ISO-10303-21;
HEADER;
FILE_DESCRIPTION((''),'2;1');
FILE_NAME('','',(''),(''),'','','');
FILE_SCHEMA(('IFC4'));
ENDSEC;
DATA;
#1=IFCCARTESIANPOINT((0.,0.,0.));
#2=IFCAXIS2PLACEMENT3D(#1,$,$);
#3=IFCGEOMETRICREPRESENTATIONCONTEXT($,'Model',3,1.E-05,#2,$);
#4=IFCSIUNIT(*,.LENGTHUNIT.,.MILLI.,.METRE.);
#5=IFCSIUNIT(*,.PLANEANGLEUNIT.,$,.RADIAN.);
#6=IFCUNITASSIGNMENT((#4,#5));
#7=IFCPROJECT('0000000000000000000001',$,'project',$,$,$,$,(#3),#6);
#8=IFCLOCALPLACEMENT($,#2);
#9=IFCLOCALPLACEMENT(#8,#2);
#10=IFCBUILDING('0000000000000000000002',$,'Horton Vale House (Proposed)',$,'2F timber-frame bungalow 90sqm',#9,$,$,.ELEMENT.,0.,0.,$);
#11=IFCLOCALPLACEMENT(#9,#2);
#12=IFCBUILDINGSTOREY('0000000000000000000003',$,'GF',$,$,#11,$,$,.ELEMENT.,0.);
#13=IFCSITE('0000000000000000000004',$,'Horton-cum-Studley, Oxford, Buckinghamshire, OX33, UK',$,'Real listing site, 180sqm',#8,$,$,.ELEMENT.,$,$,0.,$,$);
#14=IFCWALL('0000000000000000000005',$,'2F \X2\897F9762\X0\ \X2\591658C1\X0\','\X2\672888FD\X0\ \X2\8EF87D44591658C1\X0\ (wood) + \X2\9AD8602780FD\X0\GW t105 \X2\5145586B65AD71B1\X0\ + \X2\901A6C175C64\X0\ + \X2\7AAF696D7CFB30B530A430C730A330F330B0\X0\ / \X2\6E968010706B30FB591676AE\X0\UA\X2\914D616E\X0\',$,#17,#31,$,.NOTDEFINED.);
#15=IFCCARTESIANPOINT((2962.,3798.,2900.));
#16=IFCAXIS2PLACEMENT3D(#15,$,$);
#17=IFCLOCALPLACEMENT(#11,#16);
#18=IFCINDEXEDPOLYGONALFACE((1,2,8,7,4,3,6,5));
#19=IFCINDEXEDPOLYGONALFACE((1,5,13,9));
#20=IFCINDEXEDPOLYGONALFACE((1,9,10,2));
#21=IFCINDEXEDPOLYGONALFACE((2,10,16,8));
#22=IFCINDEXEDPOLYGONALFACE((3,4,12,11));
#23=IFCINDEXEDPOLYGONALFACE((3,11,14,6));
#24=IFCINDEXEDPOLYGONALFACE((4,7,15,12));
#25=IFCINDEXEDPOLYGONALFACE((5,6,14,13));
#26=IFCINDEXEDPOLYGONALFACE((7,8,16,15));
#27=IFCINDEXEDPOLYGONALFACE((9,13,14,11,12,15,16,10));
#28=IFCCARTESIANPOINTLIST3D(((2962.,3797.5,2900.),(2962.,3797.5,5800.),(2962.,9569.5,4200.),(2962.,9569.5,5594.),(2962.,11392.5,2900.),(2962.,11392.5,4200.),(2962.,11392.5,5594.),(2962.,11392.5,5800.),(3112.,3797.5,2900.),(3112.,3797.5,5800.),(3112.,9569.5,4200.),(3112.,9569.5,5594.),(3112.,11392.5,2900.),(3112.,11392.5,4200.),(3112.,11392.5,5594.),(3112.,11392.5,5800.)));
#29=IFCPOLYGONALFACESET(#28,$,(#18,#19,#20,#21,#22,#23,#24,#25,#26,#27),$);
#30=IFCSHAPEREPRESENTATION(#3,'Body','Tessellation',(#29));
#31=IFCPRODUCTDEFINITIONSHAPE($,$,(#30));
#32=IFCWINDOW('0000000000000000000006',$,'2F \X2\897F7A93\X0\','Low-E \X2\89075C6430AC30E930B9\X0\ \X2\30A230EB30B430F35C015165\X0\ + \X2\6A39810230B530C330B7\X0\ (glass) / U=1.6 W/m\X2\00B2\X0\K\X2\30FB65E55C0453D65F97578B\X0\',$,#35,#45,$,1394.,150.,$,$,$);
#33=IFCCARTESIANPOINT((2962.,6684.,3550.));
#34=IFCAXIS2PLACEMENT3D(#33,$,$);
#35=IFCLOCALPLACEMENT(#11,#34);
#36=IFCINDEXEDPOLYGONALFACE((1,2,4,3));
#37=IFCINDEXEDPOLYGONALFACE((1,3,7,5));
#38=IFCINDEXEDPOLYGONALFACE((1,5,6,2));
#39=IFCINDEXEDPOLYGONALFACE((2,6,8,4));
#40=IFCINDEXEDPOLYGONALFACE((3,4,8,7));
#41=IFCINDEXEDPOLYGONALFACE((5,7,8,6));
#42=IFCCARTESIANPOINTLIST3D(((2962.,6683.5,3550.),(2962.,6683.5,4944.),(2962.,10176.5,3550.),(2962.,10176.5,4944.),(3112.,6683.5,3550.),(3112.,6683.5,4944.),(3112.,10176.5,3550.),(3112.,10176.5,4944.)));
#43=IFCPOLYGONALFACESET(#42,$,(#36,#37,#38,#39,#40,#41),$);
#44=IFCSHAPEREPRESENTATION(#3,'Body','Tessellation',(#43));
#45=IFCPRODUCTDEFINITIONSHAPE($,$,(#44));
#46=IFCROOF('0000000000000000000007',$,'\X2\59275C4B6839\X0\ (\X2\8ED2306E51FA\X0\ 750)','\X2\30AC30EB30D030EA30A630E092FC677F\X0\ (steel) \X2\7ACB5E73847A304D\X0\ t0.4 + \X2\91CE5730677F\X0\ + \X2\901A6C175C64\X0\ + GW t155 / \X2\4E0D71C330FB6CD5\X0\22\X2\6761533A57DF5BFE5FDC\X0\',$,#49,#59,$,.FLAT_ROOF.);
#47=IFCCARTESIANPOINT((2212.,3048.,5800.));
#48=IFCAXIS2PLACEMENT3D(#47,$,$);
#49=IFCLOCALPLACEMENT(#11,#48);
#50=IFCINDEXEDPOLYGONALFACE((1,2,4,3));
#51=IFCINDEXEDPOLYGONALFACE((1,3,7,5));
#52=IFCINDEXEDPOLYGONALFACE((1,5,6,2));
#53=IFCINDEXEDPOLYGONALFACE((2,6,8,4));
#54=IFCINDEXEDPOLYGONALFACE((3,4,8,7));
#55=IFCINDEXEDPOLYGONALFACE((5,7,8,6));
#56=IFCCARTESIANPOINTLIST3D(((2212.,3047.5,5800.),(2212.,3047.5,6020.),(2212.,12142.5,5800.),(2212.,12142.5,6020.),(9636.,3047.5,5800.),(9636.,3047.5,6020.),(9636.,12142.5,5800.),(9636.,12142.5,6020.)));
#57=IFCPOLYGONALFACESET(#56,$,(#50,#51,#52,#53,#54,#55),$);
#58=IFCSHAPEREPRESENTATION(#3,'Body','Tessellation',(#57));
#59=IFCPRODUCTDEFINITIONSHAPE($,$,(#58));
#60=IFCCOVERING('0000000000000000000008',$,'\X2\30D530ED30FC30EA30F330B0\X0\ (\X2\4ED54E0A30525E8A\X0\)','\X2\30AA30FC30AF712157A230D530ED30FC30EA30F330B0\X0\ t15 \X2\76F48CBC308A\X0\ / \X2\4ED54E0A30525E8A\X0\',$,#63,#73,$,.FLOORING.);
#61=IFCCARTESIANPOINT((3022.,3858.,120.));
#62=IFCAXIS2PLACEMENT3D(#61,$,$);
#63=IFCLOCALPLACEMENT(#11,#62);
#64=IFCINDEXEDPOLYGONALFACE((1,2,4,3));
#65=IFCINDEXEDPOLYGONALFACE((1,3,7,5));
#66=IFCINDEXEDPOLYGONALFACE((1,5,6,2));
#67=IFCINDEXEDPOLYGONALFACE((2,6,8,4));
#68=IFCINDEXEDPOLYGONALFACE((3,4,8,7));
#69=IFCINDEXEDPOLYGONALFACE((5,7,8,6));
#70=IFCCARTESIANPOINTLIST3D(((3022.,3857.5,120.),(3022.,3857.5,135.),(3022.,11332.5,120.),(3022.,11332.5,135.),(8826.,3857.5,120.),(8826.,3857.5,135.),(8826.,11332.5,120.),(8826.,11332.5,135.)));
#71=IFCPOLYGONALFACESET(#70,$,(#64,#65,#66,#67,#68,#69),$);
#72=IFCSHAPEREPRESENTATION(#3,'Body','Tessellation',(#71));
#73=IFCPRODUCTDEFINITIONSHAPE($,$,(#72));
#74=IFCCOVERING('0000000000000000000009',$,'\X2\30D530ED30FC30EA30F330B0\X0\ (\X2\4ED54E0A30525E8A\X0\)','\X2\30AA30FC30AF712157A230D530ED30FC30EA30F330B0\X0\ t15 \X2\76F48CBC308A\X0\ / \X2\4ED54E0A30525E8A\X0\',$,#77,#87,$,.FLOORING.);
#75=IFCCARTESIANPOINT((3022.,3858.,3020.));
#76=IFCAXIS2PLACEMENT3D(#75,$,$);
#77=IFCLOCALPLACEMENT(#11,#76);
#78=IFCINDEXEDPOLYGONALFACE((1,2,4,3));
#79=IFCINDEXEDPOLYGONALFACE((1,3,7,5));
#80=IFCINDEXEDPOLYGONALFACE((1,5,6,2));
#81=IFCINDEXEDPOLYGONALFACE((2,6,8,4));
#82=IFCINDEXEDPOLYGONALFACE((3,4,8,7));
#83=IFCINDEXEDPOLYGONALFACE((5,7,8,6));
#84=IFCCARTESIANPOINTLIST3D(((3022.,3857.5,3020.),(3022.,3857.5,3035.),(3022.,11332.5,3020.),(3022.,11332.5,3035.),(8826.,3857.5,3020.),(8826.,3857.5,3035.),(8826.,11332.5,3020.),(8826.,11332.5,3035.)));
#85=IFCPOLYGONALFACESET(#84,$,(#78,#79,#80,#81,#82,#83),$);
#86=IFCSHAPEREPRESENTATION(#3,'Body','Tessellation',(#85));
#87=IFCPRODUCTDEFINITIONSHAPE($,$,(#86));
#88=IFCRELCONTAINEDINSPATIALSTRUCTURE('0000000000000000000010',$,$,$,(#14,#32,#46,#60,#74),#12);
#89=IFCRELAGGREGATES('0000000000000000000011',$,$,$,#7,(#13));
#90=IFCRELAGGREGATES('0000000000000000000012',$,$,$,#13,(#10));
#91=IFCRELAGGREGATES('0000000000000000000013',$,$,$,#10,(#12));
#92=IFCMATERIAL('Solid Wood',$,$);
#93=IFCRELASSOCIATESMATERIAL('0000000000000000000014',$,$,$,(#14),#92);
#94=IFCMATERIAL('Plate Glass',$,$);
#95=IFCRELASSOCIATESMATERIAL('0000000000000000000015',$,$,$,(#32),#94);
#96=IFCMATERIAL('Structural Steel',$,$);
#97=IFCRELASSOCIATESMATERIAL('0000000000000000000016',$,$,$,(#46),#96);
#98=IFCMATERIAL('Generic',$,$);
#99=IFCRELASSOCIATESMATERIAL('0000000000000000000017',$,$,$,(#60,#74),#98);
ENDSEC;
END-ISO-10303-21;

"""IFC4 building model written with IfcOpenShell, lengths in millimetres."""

from ifc_helpers import new_model, si_unit, frame, frame_2d, origin, place, context, project, spatial, rectangle, extrude, material, element, fill, save


model = new_model("IFC4")

# Units and contexts
model_context = context("Model", 3, precision=1e-05, world=origin())
ifc_project = project(units=[si_unit("LENGTHUNIT", "METRE", prefix="MILLI"), si_unit("PLANEANGLEUNIT", "RADIAN")], contexts=[model_context])

# Site, building, storey
site_placement = place(None, origin())
site = spatial("IfcSite", under=ifc_project, at=site_placement, Name="Horton-cum-Studley, Oxford, Buckinghamshire, OX33, UK", ObjectType="Real listing site, 180sqm", CompositionType="ELEMENT", RefElevation=0.0)
building_placement = place(site_placement, origin())
building = spatial("IfcBuilding", under=site, at=building_placement, Name="Horton Vale House (Proposed)", ObjectType="2F timber-frame bungalow 90sqm", CompositionType="ELEMENT", ElevationOfRefHeight=0.0, ElevationOfTerrain=0.0)
storey_placement = place(building_placement, origin())
storey = spatial("IfcBuildingStorey", under=building, at=storey_placement, Name="GF", CompositionType="ELEMENT", Elevation=0.0)

# Shared definitions
ifc_material_1 = material(Name="Solid Wood")

# Shared definitions
ifc_material_2 = material(Name="Plate Glass")

# Wall, opening, window
wall_1_placement = place(storey_placement, frame((2962.0, 3798.0, 2900.0)))
wall_1 = element("IfcWall", 1, at=wall_1_placement, inside=storey, material=ifc_material_1, Name="2F 西面 外壁", Description="木製 軸組外壁 (wood) + 高性能GW t105 充填断熱 + 通気層 + 窯業系サイディング / 準耐火・外皮UA配慮", PredefinedType="NOTDEFINED", context=model_context, shape_type="SweptSolid", body=[
    extrude(rectangle(XDim=150.0, YDim=7595.0, at=frame_2d((75.0, 3797.0))), frame((2962.0, 3798.0, 2900.0)), (0.0, 0.0, 1.0), 2900.0),
])
opening_1_placement = place(storey_placement, frame((2962.0, 6684.0, 3550.0)))
opening_1 = element("IfcOpeningElement", 2, at=opening_1_placement, cuts=wall_1, PredefinedType="NOTDEFINED", context=model_context, shape_type="SweptSolid", body=[
    extrude(rectangle(XDim=150.0, YDim=3493.0, at=frame_2d((75.0, 1746.0))), frame((2962.0, 6684.0, 3550.0)), (0.0, 0.0, 1.0), 1394.0),
])
window_1_placement = place(storey_placement, frame((2962.0, 6684.0, 3550.0)))
window_1 = element("IfcWindow", 3, at=window_1_placement, inside=storey, material=ifc_material_2, Name="2F 西窓", Description="Low-E 複層ガラス アルゴン封入 + 樹脂サッシ (glass) / U=1.6 W/m²K・日射取得型", OverallHeight=1394.0, OverallWidth=150.0, context=model_context, shape_type="SweptSolid", body=[
    extrude(rectangle(XDim=150.0, YDim=3493.0, at=frame_2d((75.0, 1746.0))), frame((2962.0, 6684.0, 3550.0)), (0.0, 0.0, 1.0), 1394.0),
])
fill(opening_1, window_1)

# Roof
ifc_material_3 = material(Name="Structural Steel")
roof_placement = place(storey_placement, frame((2212.0, 3048.0, 5800.0)))
element("IfcRoof", 4, at=roof_placement, inside=storey, material=ifc_material_3, Name="大屋根 (軒の出 750)", Description="ガルバリウム鋼板 (steel) 立平葺き t0.4 + 野地板 + 通気層 + GW t155 / 不燃・法22条区域対応", PredefinedType="FLAT_ROOF", context=model_context, shape_type="SweptSolid", body=[
    extrude(rectangle(XDim=7424.0, YDim=9095.0, at=frame_2d((3712.0, 4547.0))), frame((2212.0, 3048.0, 5800.0)), (0.0, 0.0, 1.0), 220.0),
])

# Coverings
ifc_material_4 = material(Name="Generic")
covering_1_placement = place(storey_placement, frame((3022.0, 3858.0, 120.0)))
element("IfcCovering", 5, at=covering_1_placement, inside=storey, material=ifc_material_4, Name="フローリング (仕上げ床)", Description="オーク無垢フローリング t15 直貼り / 仕上げ床", PredefinedType="FLOORING", context=model_context, shape_type="SweptSolid", body=[
    extrude(rectangle(XDim=5804.0, YDim=7475.0, at=frame_2d((2902.0, 3737.0))), frame((3022.0, 3858.0, 120.0)), (0.0, 0.0, 1.0), 15.0),
])
covering_2_placement = place(storey_placement, frame((3022.0, 3858.0, 3020.0)))
element("IfcCovering", 6, at=covering_2_placement, inside=storey, material=ifc_material_4, Name="フローリング (仕上げ床)", Description="オーク無垢フローリング t15 直貼り / 仕上げ床", PredefinedType="FLOORING", context=model_context, shape_type="SweptSolid", body=[
    extrude(rectangle(XDim=5804.0, YDim=7475.0, at=frame_2d((2902.0, 3737.0))), frame((3022.0, 3858.0, 3020.0)), (0.0, 0.0, 1.0), 15.0),
])

save(model, "model.ifc")
